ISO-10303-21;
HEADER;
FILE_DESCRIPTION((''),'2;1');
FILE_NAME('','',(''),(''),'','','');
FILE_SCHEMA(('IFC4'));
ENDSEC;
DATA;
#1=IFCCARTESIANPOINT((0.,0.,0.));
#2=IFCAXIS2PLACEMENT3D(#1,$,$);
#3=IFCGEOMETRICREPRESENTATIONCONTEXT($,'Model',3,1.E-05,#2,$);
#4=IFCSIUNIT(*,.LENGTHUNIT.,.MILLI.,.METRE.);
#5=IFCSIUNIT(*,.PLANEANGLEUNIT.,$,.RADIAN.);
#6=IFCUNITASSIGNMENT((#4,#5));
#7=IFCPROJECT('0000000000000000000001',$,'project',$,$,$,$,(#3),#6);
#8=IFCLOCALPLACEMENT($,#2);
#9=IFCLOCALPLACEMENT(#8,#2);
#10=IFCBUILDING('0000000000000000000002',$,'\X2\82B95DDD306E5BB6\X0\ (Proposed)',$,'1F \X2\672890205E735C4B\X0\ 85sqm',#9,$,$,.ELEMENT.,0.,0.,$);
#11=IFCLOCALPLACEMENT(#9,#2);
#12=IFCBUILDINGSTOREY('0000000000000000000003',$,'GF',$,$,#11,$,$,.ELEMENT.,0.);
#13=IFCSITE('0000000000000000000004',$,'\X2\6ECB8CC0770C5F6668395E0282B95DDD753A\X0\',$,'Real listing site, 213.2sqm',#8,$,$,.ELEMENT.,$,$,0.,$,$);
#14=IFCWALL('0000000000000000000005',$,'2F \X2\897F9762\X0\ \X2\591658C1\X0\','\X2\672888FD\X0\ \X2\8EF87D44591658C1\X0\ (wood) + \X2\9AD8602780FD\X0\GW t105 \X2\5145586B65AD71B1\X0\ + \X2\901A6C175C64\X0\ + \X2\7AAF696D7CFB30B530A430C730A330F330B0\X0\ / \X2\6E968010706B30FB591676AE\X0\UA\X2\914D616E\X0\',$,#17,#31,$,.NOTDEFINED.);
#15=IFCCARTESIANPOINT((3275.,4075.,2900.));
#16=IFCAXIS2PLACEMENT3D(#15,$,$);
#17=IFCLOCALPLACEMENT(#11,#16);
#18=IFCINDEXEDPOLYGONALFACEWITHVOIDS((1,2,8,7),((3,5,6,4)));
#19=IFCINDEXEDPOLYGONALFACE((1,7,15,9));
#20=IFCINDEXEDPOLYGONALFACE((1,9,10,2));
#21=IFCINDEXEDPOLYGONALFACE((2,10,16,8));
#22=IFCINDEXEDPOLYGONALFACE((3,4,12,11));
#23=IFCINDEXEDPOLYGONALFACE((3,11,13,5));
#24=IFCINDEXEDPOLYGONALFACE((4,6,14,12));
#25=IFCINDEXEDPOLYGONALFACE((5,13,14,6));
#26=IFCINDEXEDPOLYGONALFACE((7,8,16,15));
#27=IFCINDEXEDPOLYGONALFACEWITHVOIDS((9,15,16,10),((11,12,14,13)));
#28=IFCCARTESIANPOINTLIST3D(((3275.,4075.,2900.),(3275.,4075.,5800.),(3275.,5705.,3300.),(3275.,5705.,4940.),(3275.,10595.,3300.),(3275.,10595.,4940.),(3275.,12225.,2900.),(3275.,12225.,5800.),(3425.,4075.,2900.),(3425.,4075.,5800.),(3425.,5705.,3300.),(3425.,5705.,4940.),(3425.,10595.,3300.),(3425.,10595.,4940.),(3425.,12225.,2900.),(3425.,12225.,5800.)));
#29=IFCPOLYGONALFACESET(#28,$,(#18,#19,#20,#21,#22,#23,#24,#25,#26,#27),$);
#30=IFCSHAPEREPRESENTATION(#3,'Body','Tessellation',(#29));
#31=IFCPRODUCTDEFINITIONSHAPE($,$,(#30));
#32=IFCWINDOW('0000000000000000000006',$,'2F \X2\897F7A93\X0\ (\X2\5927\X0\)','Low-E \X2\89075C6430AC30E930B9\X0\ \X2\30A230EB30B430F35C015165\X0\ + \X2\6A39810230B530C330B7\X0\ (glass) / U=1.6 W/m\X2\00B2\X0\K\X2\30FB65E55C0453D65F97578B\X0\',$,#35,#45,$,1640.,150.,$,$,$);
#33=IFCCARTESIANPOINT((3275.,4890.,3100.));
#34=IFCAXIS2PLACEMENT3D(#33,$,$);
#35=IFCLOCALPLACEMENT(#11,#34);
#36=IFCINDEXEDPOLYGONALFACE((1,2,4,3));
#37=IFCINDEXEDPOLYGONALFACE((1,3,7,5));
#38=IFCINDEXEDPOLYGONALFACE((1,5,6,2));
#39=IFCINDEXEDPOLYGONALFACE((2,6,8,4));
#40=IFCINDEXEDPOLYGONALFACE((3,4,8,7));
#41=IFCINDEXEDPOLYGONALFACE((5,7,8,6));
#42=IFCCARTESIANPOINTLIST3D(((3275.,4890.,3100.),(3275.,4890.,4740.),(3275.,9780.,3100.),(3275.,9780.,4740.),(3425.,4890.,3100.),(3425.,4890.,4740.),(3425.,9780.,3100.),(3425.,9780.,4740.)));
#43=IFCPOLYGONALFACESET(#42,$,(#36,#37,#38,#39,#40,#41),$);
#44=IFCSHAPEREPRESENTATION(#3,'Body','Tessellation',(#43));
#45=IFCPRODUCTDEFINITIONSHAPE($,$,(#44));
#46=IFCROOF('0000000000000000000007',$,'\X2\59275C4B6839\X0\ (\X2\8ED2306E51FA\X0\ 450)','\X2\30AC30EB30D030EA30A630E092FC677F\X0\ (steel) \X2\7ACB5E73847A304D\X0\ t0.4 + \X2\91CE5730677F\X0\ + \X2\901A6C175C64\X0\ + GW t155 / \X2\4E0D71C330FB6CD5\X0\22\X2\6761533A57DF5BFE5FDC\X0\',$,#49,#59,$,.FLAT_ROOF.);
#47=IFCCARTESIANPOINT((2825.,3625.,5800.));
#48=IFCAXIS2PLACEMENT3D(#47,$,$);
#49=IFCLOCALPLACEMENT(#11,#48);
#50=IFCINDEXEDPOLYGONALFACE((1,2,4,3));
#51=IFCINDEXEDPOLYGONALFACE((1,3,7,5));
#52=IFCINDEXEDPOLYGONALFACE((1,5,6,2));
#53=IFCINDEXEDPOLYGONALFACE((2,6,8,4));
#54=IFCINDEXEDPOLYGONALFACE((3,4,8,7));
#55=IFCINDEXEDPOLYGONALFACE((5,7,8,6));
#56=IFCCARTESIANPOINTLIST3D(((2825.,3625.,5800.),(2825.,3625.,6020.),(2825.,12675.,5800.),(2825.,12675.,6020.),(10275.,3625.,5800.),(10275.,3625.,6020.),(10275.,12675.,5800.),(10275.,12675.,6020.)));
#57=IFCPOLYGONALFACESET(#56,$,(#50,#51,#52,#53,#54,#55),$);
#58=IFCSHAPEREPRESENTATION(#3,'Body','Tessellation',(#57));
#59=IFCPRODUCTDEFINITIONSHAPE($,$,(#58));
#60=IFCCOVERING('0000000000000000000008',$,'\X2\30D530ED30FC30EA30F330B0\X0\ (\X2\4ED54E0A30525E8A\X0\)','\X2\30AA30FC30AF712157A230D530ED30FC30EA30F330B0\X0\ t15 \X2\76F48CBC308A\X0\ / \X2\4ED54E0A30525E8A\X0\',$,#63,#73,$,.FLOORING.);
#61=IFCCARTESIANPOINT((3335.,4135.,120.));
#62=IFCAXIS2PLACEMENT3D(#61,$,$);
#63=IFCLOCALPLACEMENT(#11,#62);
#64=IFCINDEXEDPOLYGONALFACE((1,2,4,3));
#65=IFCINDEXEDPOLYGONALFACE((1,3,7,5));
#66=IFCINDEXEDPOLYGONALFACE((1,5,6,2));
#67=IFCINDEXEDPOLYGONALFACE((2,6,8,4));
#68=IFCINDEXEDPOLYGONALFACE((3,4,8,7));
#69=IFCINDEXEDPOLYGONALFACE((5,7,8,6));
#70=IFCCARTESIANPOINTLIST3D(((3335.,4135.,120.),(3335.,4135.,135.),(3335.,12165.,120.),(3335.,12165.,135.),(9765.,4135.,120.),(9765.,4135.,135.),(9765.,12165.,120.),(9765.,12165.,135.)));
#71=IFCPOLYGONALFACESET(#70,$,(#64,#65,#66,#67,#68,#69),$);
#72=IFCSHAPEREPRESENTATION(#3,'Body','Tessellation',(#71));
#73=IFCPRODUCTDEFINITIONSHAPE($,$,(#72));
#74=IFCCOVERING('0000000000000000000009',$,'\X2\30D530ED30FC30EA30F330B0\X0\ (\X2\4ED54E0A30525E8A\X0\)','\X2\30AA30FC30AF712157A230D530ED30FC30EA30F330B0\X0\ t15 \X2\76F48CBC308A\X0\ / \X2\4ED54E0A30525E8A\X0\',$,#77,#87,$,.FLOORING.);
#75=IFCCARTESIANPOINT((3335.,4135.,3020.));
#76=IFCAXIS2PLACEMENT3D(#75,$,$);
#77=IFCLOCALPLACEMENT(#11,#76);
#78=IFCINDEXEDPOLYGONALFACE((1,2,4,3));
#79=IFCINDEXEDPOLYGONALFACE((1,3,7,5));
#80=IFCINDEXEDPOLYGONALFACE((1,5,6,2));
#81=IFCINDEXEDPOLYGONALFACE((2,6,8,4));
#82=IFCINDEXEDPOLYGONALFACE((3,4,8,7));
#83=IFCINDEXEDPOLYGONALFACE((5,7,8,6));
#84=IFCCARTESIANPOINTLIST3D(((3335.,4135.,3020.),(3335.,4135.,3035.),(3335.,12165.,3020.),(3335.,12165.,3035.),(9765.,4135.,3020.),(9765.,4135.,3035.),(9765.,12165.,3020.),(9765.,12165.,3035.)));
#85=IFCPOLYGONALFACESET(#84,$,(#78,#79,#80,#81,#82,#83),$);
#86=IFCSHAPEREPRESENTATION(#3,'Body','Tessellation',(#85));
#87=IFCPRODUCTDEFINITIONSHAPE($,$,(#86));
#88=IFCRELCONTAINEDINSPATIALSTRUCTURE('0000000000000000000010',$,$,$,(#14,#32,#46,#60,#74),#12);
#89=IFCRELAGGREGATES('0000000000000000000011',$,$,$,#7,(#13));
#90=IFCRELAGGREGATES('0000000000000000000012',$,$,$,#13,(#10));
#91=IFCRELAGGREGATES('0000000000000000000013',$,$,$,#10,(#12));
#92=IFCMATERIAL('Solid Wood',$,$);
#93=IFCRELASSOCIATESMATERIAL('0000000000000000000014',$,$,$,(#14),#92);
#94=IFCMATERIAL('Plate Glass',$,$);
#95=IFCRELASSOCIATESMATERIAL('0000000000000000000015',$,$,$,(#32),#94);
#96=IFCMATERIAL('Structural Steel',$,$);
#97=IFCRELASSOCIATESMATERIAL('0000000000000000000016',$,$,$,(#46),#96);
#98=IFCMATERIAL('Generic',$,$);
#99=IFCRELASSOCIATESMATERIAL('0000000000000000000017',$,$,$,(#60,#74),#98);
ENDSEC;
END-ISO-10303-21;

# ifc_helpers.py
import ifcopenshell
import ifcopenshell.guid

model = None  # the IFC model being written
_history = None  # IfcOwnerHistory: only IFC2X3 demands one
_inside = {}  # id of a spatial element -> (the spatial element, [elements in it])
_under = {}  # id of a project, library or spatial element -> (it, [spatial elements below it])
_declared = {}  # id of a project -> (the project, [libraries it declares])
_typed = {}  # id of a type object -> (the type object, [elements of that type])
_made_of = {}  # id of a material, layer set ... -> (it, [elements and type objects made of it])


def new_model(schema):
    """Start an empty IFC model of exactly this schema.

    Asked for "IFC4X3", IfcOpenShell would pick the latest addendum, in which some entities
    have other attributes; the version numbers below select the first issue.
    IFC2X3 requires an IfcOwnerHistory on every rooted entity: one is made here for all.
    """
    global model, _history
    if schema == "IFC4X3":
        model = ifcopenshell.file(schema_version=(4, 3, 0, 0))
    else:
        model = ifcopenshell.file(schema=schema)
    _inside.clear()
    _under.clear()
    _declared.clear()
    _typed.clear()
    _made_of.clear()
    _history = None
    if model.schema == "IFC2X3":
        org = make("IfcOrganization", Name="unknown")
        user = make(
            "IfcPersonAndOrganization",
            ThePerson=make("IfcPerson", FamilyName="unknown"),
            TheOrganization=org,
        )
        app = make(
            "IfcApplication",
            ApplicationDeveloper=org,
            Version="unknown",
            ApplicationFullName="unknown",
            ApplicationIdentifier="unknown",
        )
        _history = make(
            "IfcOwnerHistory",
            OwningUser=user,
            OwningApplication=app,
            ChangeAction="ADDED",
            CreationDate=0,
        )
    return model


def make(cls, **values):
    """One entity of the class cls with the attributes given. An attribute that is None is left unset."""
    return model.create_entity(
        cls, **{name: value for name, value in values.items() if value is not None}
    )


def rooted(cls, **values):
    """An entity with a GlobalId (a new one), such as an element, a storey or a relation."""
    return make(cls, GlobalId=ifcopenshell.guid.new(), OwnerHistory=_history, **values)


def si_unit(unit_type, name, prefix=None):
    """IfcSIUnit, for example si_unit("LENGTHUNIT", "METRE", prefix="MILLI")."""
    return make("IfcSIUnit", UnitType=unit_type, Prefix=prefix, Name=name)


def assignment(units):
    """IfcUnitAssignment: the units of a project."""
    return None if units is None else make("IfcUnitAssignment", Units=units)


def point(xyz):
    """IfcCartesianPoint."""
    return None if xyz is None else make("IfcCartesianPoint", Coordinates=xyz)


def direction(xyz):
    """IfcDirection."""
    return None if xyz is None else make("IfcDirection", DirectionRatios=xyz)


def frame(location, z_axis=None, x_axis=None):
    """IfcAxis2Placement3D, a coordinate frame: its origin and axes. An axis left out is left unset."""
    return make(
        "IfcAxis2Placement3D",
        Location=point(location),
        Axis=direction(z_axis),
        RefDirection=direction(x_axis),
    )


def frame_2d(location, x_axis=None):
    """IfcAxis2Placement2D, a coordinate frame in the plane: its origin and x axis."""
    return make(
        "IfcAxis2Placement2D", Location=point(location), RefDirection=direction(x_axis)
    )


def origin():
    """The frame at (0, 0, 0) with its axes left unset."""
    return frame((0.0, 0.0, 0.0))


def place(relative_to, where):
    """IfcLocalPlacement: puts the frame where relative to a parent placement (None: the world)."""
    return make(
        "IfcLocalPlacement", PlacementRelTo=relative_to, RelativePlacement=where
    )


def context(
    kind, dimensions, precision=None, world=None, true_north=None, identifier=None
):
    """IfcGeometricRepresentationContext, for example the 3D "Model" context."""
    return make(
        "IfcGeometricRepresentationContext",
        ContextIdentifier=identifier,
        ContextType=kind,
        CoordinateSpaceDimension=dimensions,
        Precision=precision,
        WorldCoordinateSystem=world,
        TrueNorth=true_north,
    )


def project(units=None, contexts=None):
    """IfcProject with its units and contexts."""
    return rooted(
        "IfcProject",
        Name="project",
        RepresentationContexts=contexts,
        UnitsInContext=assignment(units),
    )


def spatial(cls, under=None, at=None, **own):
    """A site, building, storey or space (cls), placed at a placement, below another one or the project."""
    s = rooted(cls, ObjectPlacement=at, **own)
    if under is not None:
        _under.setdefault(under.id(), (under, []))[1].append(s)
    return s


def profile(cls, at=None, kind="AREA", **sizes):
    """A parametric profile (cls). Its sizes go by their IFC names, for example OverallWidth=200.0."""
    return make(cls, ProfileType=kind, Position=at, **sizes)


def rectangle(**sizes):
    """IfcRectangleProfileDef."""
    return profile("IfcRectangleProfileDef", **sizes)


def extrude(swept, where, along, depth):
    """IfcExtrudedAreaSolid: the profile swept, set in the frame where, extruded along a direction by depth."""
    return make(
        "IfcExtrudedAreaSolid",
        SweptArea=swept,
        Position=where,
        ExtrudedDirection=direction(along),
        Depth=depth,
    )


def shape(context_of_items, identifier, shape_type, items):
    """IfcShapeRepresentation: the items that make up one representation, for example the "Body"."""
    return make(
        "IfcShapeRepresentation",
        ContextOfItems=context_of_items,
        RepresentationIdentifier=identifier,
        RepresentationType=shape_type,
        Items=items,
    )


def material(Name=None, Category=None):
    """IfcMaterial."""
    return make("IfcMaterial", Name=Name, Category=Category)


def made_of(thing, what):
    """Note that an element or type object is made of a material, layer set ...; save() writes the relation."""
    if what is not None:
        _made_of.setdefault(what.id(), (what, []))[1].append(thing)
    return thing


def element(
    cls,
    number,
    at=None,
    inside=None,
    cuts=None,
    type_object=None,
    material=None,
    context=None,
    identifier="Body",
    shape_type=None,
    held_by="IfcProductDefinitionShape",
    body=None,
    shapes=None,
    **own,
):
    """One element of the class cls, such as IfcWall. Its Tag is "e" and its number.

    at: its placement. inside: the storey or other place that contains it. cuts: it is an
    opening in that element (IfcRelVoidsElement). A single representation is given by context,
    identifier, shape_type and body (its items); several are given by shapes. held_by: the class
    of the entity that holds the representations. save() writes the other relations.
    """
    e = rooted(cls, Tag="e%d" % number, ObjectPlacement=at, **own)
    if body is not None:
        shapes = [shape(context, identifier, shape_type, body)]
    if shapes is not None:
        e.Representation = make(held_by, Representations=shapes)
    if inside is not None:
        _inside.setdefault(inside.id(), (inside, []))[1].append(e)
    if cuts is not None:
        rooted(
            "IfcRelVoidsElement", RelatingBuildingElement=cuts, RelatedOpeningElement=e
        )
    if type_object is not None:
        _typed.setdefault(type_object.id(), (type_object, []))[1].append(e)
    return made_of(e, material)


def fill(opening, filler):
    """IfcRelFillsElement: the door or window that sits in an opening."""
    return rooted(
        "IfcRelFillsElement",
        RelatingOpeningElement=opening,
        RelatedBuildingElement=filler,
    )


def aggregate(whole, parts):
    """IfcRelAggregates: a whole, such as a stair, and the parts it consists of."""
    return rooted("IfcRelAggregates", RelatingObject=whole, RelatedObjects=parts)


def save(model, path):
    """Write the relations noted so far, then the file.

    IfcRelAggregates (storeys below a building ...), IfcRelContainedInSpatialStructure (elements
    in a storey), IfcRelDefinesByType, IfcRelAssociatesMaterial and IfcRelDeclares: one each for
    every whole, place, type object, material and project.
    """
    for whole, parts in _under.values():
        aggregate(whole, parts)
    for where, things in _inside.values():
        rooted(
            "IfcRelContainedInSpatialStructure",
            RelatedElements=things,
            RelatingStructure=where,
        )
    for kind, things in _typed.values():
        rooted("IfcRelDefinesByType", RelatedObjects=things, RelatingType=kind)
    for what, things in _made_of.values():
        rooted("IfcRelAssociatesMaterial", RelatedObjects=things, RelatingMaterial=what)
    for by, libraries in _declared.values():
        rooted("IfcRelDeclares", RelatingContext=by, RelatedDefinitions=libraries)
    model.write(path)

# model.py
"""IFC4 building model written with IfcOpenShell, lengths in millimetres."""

from ifc_helpers import new_model, si_unit, frame, frame_2d, origin, place, context, project, spatial, rectangle, extrude, material, element, fill, save


model = new_model("IFC4")

# Units and contexts
model_context = context("Model", 3, precision=1e-05, world=origin())
ifc_project = project(units=[si_unit("LENGTHUNIT", "METRE", prefix="MILLI"), si_unit("PLANEANGLEUNIT", "RADIAN")], contexts=[model_context])

# Site, building, storey
site_placement = place(None, origin())
site = spatial("IfcSite", under=ifc_project, at=site_placement, Name="滋賀県彦根市芹川町", ObjectType="Real listing site, 213.2sqm", CompositionType="ELEMENT", RefElevation=0.0)
building_placement = place(site_placement, origin())
building = spatial("IfcBuilding", under=site, at=building_placement, Name="芹川の家 (Proposed)", ObjectType="1F 木造平屋 85sqm", CompositionType="ELEMENT", ElevationOfRefHeight=0.0, ElevationOfTerrain=0.0)
storey_placement = place(building_placement, origin())
storey = spatial("IfcBuildingStorey", under=building, at=storey_placement, Name="GF", CompositionType="ELEMENT", Elevation=0.0)

# Shared definitions
ifc_material_1 = material(Name="Solid Wood")
ifc_material_2 = material(Name="Generic")

# Shared definitions
ifc_material_3 = material(Name="Plate Glass")

# Wall, opening, window
wall_1_placement = place(storey_placement, frame((3275.0, 4075.0, 2900.0)))
wall_1 = element("IfcWall", 1, at=wall_1_placement, inside=storey, material=ifc_material_1, Name="2F 西面 外壁", Description="木製 軸組外壁 (wood) + 高性能GW t105 充填断熱 + 通気層 + 窯業系サイディング / 準耐火・外皮UA配慮", PredefinedType="NOTDEFINED", context=model_context, shape_type="SweptSolid", body=[
    extrude(rectangle(XDim=150.0, YDim=8150.0, at=frame_2d((75.0, 4075.0))), frame((3275.0, 4075.0, 2900.0)), (0.0, 0.0, 1.0), 2900.0),
])
opening_1_placement = place(storey_placement, frame((3275.0, 4890.0, 3100.0)))
opening_1 = element("IfcOpeningElement", 2, at=opening_1_placement, cuts=wall_1, PredefinedType="NOTDEFINED", context=model_context, shape_type="SweptSolid", body=[
    extrude(rectangle(XDim=150.0, YDim=4890.0, at=frame_2d((75.0, 2445.0))), frame((3275.0, 4890.0, 3100.0)), (0.0, 0.0, 1.0), 1640.0),
])
window_1_placement = place(storey_placement, frame((3275.0, 4890.0, 3100.0)))
window_1 = element("IfcWindow", 3, at=window_1_placement, inside=storey, material=ifc_material_3, Name="2F 西窓 (大)", Description="Low-E 複層ガラス アルゴン封入 + 樹脂サッシ (glass) / U=1.6 W/m²K・日射取得型", OverallHeight=1640.0, OverallWidth=150.0, context=model_context, shape_type="SweptSolid", body=[
    extrude(rectangle(XDim=150.0, YDim=4890.0, at=frame_2d((75.0, 2445.0))), frame((3275.0, 4890.0, 3100.0)), (0.0, 0.0, 1.0), 1640.0),
])
fill(opening_1, window_1)

# Roof
ifc_material_4 = material(Name="Structural Steel")
roof_placement = place(storey_placement, frame((2825.0, 3625.0, 5800.0)))
element("IfcRoof", 4, at=roof_placement, inside=storey, material=ifc_material_4, Name="大屋根 (軒の出 450)", Description="ガルバリウム鋼板 (steel) 立平葺き t0.4 + 野地板 + 通気層 + GW t155 / 不燃・法22条区域対応", PredefinedType="FLAT_ROOF", context=model_context, shape_type="SweptSolid", body=[
    extrude(rectangle(XDim=7450.0, YDim=9050.0, at=frame_2d((3725.0, 4525.0))), frame((2825.0, 3625.0, 5800.0)), (0.0, 0.0, 1.0), 220.0),
])

# Coverings
covering_1_placement = place(storey_placement, frame((3335.0, 4135.0, 120.0)))
element("IfcCovering", 5, at=covering_1_placement, inside=storey, material=ifc_material_2, Name="フローリング (仕上げ床)", Description="オーク無垢フローリング t15 直貼り / 仕上げ床", PredefinedType="FLOORING", context=model_context, shape_type="SweptSolid", body=[
    extrude(rectangle(XDim=6430.0, YDim=8030.0, at=frame_2d((3215.0, 4015.0))), frame((3335.0, 4135.0, 120.0)), (0.0, 0.0, 1.0), 15.0),
])
covering_2_placement = place(storey_placement, frame((3335.0, 4135.0, 3020.0)))
element("IfcCovering", 6, at=covering_2_placement, inside=storey, material=ifc_material_2, Name="フローリング (仕上げ床)", Description="オーク無垢フローリング t15 直貼り / 仕上げ床", PredefinedType="FLOORING", context=model_context, shape_type="SweptSolid", body=[
    extrude(rectangle(XDim=6430.0, YDim=8030.0, at=frame_2d((3215.0, 4015.0))), frame((3335.0, 4135.0, 3020.0)), (0.0, 0.0, 1.0), 15.0),
])

save(model, "model.ifc")
